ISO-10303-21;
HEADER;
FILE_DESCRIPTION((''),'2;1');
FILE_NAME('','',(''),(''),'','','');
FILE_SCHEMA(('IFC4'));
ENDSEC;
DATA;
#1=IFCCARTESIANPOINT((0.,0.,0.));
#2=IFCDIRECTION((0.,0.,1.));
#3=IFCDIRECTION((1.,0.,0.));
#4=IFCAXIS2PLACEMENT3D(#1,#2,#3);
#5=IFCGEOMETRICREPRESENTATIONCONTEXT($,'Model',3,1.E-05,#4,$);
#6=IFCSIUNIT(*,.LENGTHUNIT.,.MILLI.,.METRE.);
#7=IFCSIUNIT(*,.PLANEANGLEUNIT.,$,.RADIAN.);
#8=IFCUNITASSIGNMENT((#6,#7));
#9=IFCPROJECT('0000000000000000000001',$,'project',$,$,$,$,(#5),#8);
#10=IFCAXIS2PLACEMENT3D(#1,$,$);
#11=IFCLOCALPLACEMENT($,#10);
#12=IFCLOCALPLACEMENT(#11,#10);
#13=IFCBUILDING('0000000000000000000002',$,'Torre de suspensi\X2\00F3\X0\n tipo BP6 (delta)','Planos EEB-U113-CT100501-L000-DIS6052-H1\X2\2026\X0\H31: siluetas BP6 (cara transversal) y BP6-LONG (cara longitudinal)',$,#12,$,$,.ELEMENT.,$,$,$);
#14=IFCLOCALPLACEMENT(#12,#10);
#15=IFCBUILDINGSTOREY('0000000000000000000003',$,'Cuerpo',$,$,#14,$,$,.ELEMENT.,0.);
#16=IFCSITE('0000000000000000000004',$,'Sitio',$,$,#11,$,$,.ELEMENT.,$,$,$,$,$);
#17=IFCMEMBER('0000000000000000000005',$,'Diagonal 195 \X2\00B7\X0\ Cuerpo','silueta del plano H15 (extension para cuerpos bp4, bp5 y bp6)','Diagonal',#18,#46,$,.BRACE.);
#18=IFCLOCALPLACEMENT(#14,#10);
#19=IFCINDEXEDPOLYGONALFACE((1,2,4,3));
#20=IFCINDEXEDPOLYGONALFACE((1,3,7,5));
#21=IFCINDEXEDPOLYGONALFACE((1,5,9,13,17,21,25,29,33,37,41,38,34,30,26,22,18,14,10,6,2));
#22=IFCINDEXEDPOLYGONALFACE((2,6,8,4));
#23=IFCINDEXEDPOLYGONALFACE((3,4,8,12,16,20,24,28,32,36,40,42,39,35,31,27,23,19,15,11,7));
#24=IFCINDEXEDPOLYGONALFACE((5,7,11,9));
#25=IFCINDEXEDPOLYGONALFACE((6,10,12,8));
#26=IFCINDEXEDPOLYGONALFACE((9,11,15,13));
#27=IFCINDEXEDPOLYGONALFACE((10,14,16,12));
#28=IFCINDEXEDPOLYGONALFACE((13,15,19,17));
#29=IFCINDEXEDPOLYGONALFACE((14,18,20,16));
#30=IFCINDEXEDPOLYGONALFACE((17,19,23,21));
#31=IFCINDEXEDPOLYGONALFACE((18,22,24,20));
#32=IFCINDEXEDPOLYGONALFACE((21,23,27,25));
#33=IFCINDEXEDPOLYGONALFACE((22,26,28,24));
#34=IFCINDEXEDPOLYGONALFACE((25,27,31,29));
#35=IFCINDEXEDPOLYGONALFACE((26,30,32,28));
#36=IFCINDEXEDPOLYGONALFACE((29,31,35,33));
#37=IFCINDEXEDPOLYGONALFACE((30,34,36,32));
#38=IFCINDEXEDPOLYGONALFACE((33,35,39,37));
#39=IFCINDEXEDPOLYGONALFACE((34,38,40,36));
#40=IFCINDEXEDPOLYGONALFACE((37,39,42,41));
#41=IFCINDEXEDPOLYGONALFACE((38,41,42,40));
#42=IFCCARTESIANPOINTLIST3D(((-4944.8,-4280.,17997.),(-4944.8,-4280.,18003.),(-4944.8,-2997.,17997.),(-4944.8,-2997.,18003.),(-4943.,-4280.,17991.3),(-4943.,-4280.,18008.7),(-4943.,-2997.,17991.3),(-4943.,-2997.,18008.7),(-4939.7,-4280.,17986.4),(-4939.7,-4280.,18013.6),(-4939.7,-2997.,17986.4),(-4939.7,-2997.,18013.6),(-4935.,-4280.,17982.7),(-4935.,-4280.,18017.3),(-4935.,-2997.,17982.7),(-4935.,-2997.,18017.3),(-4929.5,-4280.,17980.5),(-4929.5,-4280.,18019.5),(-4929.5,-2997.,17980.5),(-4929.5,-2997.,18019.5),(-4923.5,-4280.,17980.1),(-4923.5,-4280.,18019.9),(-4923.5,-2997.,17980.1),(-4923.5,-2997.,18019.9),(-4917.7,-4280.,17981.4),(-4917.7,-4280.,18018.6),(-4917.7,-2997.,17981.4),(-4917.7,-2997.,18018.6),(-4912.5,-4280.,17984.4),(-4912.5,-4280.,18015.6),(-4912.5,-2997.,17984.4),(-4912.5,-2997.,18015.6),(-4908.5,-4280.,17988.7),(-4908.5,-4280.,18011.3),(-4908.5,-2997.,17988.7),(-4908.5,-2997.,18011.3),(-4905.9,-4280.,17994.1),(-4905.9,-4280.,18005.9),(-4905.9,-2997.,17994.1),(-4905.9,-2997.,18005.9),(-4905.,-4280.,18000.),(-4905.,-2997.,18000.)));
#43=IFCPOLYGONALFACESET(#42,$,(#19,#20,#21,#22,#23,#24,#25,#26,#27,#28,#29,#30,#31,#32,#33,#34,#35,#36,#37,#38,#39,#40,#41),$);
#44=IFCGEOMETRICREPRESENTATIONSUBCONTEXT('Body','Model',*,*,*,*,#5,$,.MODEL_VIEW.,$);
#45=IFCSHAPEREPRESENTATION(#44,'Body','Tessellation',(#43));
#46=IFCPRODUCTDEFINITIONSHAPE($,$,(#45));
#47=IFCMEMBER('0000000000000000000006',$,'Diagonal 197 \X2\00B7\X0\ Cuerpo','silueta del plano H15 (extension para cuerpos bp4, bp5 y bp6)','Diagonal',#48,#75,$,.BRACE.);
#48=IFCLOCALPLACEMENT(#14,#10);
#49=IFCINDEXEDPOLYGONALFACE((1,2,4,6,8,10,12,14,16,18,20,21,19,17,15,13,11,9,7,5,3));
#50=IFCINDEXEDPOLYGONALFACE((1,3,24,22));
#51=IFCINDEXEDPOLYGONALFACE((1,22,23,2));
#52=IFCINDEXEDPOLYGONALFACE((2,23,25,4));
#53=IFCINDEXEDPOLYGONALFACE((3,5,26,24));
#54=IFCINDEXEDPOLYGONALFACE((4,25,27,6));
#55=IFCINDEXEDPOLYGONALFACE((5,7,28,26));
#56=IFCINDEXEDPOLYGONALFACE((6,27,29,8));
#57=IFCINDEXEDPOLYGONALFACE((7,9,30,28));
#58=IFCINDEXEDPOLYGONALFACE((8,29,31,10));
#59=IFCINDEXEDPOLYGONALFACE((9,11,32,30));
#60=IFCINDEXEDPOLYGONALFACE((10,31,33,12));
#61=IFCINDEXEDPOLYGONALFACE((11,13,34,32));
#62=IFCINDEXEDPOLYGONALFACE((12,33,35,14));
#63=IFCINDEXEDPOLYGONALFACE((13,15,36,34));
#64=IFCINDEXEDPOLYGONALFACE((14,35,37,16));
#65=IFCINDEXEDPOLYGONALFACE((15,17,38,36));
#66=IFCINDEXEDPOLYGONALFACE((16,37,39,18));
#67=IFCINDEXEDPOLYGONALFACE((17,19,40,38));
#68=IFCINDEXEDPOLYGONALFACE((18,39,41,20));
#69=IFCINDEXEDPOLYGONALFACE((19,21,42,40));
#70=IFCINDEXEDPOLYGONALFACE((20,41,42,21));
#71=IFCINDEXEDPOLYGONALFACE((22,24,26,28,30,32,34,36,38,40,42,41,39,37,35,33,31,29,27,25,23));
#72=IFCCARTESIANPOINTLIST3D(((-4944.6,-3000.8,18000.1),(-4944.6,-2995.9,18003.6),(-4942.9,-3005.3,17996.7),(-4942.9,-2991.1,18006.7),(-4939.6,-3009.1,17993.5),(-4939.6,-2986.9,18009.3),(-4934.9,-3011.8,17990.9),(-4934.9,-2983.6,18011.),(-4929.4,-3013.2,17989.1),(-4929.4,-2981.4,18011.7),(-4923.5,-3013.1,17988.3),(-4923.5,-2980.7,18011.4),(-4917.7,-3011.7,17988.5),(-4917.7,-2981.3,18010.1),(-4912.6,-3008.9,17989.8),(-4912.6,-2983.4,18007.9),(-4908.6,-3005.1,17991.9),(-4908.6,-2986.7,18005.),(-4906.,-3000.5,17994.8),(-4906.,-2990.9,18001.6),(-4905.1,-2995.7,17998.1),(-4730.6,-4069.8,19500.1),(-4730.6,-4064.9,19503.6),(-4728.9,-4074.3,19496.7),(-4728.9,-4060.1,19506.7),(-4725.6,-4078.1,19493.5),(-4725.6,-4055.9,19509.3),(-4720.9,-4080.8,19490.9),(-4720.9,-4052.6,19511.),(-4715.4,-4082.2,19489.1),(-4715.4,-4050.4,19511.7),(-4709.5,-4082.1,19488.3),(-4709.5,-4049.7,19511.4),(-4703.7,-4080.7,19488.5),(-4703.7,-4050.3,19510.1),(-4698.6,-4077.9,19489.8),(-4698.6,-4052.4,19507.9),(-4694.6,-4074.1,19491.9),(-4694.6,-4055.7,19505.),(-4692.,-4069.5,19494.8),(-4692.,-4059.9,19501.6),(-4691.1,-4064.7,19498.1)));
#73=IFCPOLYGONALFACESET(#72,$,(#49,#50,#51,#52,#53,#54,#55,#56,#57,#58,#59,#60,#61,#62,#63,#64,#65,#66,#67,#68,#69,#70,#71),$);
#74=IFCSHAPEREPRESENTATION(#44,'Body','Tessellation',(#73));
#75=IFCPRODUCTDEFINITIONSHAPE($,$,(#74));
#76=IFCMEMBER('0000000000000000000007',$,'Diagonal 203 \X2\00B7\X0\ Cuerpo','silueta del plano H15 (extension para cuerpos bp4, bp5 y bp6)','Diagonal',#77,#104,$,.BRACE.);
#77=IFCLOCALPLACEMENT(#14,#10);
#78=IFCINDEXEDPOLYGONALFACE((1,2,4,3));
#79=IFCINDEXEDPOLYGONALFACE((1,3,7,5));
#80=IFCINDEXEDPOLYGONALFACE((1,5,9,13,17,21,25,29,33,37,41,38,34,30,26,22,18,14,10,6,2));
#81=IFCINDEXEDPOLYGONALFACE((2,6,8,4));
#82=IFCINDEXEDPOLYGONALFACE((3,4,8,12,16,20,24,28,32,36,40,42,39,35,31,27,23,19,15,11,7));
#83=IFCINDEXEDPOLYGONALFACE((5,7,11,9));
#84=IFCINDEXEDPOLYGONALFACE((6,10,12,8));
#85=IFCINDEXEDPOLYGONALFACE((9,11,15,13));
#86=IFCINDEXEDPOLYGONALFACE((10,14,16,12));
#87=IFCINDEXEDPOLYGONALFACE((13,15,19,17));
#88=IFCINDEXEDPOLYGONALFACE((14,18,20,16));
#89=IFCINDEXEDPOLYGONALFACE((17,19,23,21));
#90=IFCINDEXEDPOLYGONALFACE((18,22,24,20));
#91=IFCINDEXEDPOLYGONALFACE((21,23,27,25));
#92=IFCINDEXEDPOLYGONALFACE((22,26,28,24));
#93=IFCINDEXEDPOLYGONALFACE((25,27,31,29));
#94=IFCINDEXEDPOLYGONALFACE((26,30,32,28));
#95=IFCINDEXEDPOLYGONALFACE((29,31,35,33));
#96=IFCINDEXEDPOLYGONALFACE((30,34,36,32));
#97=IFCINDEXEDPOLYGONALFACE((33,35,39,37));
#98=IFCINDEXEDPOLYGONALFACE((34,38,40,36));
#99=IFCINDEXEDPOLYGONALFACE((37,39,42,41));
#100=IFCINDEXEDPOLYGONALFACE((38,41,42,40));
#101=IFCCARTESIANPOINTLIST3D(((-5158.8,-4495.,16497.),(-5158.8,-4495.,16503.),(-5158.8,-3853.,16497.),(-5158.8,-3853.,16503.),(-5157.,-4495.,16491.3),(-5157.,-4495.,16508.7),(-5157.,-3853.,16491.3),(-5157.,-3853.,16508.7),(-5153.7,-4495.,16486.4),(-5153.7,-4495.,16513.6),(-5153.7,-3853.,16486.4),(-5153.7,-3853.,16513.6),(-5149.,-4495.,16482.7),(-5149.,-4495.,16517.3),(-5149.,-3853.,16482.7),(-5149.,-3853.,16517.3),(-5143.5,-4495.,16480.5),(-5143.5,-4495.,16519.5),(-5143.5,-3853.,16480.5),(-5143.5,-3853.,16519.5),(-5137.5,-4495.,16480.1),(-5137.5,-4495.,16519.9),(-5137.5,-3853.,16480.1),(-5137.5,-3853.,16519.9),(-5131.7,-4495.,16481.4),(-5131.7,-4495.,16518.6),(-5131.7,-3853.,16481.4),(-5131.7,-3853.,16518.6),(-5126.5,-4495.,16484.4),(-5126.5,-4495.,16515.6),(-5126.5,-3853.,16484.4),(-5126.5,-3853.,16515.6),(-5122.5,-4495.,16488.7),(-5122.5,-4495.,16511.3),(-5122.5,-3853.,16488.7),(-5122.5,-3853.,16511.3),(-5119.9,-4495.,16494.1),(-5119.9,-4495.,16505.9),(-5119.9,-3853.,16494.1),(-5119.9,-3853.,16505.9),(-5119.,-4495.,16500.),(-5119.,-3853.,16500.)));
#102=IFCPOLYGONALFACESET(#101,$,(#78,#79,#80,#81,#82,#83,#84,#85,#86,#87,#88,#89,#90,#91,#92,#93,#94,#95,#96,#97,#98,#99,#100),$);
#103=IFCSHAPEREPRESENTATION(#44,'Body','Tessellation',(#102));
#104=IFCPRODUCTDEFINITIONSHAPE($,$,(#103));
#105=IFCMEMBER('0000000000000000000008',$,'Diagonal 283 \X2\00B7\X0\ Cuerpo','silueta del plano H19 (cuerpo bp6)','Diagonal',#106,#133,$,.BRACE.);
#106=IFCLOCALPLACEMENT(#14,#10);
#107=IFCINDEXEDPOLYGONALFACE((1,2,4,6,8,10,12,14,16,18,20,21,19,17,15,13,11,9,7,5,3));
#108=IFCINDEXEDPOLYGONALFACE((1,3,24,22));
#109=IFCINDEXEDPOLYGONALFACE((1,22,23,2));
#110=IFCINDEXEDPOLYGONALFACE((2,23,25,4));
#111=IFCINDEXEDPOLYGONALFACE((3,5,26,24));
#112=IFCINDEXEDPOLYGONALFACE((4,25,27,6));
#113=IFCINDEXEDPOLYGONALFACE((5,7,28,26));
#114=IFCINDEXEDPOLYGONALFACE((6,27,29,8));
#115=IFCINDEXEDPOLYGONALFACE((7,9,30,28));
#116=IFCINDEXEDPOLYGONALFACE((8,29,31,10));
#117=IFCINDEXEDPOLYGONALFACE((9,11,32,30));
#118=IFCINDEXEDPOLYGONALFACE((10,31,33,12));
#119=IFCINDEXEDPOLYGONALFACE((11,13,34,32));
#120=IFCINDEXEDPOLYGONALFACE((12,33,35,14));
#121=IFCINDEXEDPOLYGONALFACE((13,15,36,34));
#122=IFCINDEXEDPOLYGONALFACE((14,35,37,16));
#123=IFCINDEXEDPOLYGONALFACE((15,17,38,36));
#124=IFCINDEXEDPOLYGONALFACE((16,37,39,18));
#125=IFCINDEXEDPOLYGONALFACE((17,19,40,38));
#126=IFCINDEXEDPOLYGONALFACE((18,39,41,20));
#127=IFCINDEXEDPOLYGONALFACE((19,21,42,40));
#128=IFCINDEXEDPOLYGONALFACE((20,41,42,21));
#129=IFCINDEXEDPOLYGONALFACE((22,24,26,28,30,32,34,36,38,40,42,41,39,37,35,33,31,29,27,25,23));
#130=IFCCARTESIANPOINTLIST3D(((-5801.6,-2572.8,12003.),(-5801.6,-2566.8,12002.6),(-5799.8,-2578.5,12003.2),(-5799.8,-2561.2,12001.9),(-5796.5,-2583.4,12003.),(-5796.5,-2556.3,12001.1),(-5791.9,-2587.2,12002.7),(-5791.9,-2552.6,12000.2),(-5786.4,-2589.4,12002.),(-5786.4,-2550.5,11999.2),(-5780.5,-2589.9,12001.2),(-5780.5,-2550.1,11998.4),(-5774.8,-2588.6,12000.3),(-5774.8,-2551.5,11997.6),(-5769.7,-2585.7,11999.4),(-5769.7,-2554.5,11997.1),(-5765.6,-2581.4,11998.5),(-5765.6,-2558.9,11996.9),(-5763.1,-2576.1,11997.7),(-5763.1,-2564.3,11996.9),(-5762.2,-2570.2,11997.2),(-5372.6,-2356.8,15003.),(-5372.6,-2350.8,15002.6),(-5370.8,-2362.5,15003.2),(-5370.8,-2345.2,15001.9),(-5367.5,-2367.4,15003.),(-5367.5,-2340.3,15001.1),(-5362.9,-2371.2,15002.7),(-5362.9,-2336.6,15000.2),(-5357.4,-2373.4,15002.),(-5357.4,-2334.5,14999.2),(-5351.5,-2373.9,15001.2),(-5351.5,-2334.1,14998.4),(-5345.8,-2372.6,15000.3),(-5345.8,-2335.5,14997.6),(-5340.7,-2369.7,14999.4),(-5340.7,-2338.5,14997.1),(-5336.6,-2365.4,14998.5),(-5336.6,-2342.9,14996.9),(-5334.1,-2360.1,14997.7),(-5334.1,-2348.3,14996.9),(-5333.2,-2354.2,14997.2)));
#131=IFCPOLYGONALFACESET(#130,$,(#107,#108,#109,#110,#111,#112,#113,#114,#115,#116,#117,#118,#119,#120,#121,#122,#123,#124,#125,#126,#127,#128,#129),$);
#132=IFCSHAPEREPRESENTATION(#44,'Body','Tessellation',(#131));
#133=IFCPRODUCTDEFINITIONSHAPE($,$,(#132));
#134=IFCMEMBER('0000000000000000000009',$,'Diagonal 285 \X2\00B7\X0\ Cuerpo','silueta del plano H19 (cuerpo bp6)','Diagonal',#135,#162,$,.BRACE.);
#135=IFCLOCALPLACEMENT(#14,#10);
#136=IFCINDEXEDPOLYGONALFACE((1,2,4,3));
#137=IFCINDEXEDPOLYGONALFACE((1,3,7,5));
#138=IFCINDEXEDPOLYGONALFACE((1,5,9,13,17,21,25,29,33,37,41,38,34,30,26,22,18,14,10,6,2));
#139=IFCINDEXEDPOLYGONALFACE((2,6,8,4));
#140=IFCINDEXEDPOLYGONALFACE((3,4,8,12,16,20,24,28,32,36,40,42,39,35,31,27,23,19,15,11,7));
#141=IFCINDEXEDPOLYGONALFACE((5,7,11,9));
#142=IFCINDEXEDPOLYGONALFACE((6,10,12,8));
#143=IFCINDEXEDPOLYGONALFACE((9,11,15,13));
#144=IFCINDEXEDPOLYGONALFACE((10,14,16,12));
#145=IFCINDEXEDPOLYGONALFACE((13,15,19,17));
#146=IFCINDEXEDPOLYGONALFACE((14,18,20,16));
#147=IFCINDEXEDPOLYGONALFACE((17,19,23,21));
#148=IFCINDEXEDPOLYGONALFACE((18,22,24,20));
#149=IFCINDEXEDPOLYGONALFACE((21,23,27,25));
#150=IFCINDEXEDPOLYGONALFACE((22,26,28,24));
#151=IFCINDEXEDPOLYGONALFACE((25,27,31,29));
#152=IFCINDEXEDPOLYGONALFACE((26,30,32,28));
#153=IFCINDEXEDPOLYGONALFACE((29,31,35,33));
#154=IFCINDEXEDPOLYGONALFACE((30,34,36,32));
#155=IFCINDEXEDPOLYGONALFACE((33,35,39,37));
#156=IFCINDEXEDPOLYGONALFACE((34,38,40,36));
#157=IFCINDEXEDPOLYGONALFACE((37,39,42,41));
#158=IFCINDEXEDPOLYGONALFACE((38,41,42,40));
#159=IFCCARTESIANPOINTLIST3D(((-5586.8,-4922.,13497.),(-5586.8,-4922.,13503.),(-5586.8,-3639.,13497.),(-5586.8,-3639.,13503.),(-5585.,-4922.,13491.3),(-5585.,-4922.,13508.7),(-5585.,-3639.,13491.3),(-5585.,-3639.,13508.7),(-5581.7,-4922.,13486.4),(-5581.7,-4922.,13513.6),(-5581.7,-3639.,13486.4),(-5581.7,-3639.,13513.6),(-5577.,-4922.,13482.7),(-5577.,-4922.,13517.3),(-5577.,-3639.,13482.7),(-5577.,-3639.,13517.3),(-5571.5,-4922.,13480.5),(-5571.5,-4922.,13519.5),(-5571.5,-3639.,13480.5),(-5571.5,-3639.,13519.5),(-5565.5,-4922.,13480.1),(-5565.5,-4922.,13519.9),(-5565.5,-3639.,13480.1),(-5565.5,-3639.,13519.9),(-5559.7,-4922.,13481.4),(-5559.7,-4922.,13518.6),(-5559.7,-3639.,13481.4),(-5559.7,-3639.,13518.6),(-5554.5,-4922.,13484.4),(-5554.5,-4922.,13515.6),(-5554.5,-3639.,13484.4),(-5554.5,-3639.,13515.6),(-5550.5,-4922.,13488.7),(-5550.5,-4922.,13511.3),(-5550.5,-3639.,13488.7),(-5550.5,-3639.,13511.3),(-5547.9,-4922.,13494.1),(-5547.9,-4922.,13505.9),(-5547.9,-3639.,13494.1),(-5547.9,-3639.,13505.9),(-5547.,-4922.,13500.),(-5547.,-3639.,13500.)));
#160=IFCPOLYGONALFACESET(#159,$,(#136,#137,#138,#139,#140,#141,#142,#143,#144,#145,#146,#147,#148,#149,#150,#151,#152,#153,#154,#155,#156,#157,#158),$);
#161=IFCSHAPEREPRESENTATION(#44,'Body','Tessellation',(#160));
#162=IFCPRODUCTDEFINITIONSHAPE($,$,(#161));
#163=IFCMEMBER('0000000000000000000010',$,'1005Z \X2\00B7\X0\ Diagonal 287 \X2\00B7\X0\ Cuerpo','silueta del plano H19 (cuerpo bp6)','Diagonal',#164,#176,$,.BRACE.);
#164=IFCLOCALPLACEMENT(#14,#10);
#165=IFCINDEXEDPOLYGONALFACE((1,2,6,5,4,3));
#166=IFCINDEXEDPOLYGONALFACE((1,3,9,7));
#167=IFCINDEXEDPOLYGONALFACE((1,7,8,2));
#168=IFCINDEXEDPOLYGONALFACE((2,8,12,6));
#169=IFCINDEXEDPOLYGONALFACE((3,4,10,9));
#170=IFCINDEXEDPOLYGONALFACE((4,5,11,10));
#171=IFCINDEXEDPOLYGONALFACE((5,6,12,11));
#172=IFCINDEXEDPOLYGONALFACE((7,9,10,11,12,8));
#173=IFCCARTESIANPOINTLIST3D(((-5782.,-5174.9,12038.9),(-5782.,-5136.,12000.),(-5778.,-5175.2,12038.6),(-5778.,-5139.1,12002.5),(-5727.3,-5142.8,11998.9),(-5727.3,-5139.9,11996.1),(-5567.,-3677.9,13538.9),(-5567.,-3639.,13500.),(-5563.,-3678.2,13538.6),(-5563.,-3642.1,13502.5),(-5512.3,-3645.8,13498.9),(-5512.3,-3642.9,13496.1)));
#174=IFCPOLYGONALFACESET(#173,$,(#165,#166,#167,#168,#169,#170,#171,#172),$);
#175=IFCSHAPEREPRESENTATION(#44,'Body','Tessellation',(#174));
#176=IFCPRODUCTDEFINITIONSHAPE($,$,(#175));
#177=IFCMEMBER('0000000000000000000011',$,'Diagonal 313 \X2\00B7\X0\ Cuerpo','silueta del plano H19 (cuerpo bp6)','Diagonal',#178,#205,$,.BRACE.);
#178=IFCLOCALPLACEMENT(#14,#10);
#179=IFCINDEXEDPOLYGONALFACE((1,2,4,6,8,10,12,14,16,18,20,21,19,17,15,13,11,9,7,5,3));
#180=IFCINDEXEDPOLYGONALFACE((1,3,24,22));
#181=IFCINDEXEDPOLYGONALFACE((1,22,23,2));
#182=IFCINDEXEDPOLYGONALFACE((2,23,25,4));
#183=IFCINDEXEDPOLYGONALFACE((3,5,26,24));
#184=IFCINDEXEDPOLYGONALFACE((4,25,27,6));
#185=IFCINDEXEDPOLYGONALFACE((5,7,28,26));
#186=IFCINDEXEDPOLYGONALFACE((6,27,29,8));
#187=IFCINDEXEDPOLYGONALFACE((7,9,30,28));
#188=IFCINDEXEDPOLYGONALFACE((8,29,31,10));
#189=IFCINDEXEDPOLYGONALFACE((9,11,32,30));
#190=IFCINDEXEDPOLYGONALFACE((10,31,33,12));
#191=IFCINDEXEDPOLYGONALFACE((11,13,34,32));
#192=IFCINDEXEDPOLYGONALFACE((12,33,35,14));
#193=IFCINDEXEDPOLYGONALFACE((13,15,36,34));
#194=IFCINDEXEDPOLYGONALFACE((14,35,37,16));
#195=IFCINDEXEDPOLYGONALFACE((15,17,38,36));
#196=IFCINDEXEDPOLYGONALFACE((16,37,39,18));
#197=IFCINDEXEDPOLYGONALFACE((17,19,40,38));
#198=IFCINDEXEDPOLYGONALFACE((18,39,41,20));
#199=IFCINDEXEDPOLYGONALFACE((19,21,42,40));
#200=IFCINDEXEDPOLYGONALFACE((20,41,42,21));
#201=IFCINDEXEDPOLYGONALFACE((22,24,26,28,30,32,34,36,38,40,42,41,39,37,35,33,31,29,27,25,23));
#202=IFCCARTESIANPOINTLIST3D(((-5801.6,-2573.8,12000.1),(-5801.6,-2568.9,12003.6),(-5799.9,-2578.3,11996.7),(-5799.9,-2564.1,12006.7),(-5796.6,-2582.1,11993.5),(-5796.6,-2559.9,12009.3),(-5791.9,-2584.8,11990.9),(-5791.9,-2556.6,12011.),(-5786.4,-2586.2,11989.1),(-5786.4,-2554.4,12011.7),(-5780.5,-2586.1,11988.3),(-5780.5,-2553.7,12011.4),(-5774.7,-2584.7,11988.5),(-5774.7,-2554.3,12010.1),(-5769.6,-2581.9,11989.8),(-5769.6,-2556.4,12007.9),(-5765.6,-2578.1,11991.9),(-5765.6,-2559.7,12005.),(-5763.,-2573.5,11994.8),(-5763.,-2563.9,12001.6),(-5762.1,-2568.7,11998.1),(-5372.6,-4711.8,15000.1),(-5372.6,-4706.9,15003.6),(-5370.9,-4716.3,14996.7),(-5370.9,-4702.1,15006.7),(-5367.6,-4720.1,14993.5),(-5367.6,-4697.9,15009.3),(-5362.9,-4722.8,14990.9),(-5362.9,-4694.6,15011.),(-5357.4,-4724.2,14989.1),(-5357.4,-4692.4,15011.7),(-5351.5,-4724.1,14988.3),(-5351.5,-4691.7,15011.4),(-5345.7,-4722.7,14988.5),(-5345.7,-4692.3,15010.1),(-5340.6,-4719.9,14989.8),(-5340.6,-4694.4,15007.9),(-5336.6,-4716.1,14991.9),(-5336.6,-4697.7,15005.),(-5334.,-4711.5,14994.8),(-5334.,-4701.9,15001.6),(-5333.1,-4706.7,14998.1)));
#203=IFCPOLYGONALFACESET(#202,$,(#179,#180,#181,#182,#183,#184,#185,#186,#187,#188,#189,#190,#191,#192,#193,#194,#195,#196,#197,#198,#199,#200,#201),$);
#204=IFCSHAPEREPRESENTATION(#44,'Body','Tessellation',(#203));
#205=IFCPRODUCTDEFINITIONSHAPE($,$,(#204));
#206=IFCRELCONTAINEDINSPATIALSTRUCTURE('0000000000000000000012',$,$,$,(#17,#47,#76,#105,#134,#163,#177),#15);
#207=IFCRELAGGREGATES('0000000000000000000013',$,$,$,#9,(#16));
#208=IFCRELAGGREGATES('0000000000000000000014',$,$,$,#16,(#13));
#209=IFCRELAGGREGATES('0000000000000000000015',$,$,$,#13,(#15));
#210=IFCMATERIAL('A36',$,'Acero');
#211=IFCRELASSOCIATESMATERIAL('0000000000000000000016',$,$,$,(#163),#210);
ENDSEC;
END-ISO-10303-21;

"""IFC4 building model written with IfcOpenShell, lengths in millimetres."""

from ifc_helpers import new_model, si_unit, frame, frame_2d, origin, origin_with_axes, place, context, subcontext, project, spatial, circle, l_section, extrude, material, element, save


model = new_model("IFC4")

# Units and contexts
model_context = context("Model", 3, precision=1e-05, world=origin_with_axes())
body_context = subcontext(model_context, "Body", "Model", "MODEL_VIEW")
ifc_project = project(units=[si_unit("LENGTHUNIT", "METRE", prefix="MILLI"), si_unit("PLANEANGLEUNIT", "RADIAN")], contexts=[model_context])

# Site, building, storey
site_placement = place(None, origin())
site = spatial("IfcSite", under=ifc_project, at=site_placement, Name="Sitio", CompositionType="ELEMENT")
building_placement = place(site_placement, origin())
building = spatial("IfcBuilding", under=site, at=building_placement, Name="Torre de suspensión tipo BP6 (delta)", Description="Planos EEB-U113-CT100501-L000-DIS6052-H1…H31: siluetas BP6 (cara transversal) y BP6-LONG (cara longitudinal)", CompositionType="ELEMENT")
storey_placement = place(building_placement, origin())
storey = spatial("IfcBuildingStorey", under=building, at=storey_placement, Name="Cuerpo", CompositionType="ELEMENT", Elevation=0.0)

# Members
member_1_placement = place(storey_placement, frame((-4925.0, -2997.0, 18000.0), z_axis=(0.0, -1.0, 0.0), x_axis=(1.0, 0.0, 0.0)))
element("IfcMember", 1, at=member_1_placement, inside=storey, Name="Diagonal 195 · Cuerpo", Description="silueta del plano H15 (extension para cuerpos bp4, bp5 y bp6)", ObjectType="Diagonal", PredefinedType="BRACE", context=body_context, shape_type="SweptSolid", body=[
    extrude(circle(Radius=20.0), None, (0.0, 0.0, 1.0), 1283.0),
])
member_2_placement = place(storey_placement, frame((-4925.0, -2997.0, 18000.0), z_axis=(0.115405, -0.576487, 0.808915), x_axis=(0.993318, 0.066977, -0.093981)))
element("IfcMember", 2, at=member_2_placement, inside=storey, Name="Diagonal 197 · Cuerpo", Description="silueta del plano H15 (extension para cuerpos bp4, bp5 y bp6)", ObjectType="Diagonal", PredefinedType="BRACE", context=body_context, shape_type="SweptSolid", body=[
    extrude(circle(Radius=20.0), None, (0.0, 0.0, 1.0), 1854.3),
])
member_3_placement = place(storey_placement, frame((-5139.0, -3853.0, 16500.0), z_axis=(0.0, -1.0, 0.0), x_axis=(1.0, 0.0, 0.0)))
element("IfcMember", 3, at=member_3_placement, inside=storey, Name="Diagonal 203 · Cuerpo", Description="silueta del plano H15 (extension para cuerpos bp4, bp5 y bp6)", ObjectType="Diagonal", PredefinedType="BRACE", context=body_context, shape_type="SweptSolid", body=[
    extrude(circle(Radius=20.0), None, (0.0, 0.0, 1.0), 642.0),
])
member_4_placement = place(storey_placement, frame((-5782.0, -2570.0, 12000.0), z_axis=(0.141202, 0.071095, 0.987425), x_axis=(0.989981, -0.01014, -0.140837)))
element("IfcMember", 4, at=member_4_placement, inside=storey, Name="Diagonal 283 · Cuerpo", Description="silueta del plano H19 (cuerpo bp6)", ObjectType="Diagonal", PredefinedType="BRACE", context=body_context, shape_type="SweptSolid", body=[
    extrude(circle(Radius=20.0), None, (0.0, 0.0, 1.0), 3038.2),
])
member_5_placement = place(storey_placement, frame((-5567.0, -4922.0, 13500.0), z_axis=(0.0, 1.0, 0.0), x_axis=(1.0, 0.0, 0.0)))
element("IfcMember", 5, at=member_5_placement, inside=storey, Name="Diagonal 285 · Cuerpo", Description="silueta del plano H19 (cuerpo bp6)", ObjectType="Diagonal", PredefinedType="BRACE", context=body_context, shape_type="SweptSolid", body=[
    extrude(circle(Radius=20.0), None, (0.0, 0.0, 1.0), 1283.0),
])
ifc_material = material(Name="A36", Category="Acero")
member_6_placement = place(storey_placement, frame((-5567.0, -3639.0, 13500.0), z_axis=(-0.100935, -0.702791, -0.704199), x_axis=(0.994893, -0.071301, -0.071443)))
element("IfcMember", 6, at=member_6_placement, inside=storey, material=ifc_material, Name="1005Z · Diagonal 287 · Cuerpo", Description="silueta del plano H19 (cuerpo bp6)", ObjectType="Diagonal", PredefinedType="BRACE", context=body_context, shape_type="SweptSolid", body=[
    extrude(l_section(Depth=55.0, Width=55.0, Thickness=4.0, at=frame_2d((27.5, 27.5))), None, (0.0, 0.0, 1.0), 2130.1),
])
member_7_placement = place(storey_placement, frame((-5353.0, -4708.0, 15000.0), z_axis=(-0.115671, 0.576469, -0.80889), x_axis=(0.993288, 0.067132, -0.094198)))
element("IfcMember", 7, at=member_7_placement, inside=storey, Name="Diagonal 313 · Cuerpo", Description="silueta del plano H19 (cuerpo bp6)", ObjectType="Diagonal", PredefinedType="BRACE", context=body_context, shape_type="SweptSolid", body=[
    extrude(circle(Radius=20.0), None, (0.0, 0.0, 1.0), 3708.8),
])

save(model, "model.ifc")
